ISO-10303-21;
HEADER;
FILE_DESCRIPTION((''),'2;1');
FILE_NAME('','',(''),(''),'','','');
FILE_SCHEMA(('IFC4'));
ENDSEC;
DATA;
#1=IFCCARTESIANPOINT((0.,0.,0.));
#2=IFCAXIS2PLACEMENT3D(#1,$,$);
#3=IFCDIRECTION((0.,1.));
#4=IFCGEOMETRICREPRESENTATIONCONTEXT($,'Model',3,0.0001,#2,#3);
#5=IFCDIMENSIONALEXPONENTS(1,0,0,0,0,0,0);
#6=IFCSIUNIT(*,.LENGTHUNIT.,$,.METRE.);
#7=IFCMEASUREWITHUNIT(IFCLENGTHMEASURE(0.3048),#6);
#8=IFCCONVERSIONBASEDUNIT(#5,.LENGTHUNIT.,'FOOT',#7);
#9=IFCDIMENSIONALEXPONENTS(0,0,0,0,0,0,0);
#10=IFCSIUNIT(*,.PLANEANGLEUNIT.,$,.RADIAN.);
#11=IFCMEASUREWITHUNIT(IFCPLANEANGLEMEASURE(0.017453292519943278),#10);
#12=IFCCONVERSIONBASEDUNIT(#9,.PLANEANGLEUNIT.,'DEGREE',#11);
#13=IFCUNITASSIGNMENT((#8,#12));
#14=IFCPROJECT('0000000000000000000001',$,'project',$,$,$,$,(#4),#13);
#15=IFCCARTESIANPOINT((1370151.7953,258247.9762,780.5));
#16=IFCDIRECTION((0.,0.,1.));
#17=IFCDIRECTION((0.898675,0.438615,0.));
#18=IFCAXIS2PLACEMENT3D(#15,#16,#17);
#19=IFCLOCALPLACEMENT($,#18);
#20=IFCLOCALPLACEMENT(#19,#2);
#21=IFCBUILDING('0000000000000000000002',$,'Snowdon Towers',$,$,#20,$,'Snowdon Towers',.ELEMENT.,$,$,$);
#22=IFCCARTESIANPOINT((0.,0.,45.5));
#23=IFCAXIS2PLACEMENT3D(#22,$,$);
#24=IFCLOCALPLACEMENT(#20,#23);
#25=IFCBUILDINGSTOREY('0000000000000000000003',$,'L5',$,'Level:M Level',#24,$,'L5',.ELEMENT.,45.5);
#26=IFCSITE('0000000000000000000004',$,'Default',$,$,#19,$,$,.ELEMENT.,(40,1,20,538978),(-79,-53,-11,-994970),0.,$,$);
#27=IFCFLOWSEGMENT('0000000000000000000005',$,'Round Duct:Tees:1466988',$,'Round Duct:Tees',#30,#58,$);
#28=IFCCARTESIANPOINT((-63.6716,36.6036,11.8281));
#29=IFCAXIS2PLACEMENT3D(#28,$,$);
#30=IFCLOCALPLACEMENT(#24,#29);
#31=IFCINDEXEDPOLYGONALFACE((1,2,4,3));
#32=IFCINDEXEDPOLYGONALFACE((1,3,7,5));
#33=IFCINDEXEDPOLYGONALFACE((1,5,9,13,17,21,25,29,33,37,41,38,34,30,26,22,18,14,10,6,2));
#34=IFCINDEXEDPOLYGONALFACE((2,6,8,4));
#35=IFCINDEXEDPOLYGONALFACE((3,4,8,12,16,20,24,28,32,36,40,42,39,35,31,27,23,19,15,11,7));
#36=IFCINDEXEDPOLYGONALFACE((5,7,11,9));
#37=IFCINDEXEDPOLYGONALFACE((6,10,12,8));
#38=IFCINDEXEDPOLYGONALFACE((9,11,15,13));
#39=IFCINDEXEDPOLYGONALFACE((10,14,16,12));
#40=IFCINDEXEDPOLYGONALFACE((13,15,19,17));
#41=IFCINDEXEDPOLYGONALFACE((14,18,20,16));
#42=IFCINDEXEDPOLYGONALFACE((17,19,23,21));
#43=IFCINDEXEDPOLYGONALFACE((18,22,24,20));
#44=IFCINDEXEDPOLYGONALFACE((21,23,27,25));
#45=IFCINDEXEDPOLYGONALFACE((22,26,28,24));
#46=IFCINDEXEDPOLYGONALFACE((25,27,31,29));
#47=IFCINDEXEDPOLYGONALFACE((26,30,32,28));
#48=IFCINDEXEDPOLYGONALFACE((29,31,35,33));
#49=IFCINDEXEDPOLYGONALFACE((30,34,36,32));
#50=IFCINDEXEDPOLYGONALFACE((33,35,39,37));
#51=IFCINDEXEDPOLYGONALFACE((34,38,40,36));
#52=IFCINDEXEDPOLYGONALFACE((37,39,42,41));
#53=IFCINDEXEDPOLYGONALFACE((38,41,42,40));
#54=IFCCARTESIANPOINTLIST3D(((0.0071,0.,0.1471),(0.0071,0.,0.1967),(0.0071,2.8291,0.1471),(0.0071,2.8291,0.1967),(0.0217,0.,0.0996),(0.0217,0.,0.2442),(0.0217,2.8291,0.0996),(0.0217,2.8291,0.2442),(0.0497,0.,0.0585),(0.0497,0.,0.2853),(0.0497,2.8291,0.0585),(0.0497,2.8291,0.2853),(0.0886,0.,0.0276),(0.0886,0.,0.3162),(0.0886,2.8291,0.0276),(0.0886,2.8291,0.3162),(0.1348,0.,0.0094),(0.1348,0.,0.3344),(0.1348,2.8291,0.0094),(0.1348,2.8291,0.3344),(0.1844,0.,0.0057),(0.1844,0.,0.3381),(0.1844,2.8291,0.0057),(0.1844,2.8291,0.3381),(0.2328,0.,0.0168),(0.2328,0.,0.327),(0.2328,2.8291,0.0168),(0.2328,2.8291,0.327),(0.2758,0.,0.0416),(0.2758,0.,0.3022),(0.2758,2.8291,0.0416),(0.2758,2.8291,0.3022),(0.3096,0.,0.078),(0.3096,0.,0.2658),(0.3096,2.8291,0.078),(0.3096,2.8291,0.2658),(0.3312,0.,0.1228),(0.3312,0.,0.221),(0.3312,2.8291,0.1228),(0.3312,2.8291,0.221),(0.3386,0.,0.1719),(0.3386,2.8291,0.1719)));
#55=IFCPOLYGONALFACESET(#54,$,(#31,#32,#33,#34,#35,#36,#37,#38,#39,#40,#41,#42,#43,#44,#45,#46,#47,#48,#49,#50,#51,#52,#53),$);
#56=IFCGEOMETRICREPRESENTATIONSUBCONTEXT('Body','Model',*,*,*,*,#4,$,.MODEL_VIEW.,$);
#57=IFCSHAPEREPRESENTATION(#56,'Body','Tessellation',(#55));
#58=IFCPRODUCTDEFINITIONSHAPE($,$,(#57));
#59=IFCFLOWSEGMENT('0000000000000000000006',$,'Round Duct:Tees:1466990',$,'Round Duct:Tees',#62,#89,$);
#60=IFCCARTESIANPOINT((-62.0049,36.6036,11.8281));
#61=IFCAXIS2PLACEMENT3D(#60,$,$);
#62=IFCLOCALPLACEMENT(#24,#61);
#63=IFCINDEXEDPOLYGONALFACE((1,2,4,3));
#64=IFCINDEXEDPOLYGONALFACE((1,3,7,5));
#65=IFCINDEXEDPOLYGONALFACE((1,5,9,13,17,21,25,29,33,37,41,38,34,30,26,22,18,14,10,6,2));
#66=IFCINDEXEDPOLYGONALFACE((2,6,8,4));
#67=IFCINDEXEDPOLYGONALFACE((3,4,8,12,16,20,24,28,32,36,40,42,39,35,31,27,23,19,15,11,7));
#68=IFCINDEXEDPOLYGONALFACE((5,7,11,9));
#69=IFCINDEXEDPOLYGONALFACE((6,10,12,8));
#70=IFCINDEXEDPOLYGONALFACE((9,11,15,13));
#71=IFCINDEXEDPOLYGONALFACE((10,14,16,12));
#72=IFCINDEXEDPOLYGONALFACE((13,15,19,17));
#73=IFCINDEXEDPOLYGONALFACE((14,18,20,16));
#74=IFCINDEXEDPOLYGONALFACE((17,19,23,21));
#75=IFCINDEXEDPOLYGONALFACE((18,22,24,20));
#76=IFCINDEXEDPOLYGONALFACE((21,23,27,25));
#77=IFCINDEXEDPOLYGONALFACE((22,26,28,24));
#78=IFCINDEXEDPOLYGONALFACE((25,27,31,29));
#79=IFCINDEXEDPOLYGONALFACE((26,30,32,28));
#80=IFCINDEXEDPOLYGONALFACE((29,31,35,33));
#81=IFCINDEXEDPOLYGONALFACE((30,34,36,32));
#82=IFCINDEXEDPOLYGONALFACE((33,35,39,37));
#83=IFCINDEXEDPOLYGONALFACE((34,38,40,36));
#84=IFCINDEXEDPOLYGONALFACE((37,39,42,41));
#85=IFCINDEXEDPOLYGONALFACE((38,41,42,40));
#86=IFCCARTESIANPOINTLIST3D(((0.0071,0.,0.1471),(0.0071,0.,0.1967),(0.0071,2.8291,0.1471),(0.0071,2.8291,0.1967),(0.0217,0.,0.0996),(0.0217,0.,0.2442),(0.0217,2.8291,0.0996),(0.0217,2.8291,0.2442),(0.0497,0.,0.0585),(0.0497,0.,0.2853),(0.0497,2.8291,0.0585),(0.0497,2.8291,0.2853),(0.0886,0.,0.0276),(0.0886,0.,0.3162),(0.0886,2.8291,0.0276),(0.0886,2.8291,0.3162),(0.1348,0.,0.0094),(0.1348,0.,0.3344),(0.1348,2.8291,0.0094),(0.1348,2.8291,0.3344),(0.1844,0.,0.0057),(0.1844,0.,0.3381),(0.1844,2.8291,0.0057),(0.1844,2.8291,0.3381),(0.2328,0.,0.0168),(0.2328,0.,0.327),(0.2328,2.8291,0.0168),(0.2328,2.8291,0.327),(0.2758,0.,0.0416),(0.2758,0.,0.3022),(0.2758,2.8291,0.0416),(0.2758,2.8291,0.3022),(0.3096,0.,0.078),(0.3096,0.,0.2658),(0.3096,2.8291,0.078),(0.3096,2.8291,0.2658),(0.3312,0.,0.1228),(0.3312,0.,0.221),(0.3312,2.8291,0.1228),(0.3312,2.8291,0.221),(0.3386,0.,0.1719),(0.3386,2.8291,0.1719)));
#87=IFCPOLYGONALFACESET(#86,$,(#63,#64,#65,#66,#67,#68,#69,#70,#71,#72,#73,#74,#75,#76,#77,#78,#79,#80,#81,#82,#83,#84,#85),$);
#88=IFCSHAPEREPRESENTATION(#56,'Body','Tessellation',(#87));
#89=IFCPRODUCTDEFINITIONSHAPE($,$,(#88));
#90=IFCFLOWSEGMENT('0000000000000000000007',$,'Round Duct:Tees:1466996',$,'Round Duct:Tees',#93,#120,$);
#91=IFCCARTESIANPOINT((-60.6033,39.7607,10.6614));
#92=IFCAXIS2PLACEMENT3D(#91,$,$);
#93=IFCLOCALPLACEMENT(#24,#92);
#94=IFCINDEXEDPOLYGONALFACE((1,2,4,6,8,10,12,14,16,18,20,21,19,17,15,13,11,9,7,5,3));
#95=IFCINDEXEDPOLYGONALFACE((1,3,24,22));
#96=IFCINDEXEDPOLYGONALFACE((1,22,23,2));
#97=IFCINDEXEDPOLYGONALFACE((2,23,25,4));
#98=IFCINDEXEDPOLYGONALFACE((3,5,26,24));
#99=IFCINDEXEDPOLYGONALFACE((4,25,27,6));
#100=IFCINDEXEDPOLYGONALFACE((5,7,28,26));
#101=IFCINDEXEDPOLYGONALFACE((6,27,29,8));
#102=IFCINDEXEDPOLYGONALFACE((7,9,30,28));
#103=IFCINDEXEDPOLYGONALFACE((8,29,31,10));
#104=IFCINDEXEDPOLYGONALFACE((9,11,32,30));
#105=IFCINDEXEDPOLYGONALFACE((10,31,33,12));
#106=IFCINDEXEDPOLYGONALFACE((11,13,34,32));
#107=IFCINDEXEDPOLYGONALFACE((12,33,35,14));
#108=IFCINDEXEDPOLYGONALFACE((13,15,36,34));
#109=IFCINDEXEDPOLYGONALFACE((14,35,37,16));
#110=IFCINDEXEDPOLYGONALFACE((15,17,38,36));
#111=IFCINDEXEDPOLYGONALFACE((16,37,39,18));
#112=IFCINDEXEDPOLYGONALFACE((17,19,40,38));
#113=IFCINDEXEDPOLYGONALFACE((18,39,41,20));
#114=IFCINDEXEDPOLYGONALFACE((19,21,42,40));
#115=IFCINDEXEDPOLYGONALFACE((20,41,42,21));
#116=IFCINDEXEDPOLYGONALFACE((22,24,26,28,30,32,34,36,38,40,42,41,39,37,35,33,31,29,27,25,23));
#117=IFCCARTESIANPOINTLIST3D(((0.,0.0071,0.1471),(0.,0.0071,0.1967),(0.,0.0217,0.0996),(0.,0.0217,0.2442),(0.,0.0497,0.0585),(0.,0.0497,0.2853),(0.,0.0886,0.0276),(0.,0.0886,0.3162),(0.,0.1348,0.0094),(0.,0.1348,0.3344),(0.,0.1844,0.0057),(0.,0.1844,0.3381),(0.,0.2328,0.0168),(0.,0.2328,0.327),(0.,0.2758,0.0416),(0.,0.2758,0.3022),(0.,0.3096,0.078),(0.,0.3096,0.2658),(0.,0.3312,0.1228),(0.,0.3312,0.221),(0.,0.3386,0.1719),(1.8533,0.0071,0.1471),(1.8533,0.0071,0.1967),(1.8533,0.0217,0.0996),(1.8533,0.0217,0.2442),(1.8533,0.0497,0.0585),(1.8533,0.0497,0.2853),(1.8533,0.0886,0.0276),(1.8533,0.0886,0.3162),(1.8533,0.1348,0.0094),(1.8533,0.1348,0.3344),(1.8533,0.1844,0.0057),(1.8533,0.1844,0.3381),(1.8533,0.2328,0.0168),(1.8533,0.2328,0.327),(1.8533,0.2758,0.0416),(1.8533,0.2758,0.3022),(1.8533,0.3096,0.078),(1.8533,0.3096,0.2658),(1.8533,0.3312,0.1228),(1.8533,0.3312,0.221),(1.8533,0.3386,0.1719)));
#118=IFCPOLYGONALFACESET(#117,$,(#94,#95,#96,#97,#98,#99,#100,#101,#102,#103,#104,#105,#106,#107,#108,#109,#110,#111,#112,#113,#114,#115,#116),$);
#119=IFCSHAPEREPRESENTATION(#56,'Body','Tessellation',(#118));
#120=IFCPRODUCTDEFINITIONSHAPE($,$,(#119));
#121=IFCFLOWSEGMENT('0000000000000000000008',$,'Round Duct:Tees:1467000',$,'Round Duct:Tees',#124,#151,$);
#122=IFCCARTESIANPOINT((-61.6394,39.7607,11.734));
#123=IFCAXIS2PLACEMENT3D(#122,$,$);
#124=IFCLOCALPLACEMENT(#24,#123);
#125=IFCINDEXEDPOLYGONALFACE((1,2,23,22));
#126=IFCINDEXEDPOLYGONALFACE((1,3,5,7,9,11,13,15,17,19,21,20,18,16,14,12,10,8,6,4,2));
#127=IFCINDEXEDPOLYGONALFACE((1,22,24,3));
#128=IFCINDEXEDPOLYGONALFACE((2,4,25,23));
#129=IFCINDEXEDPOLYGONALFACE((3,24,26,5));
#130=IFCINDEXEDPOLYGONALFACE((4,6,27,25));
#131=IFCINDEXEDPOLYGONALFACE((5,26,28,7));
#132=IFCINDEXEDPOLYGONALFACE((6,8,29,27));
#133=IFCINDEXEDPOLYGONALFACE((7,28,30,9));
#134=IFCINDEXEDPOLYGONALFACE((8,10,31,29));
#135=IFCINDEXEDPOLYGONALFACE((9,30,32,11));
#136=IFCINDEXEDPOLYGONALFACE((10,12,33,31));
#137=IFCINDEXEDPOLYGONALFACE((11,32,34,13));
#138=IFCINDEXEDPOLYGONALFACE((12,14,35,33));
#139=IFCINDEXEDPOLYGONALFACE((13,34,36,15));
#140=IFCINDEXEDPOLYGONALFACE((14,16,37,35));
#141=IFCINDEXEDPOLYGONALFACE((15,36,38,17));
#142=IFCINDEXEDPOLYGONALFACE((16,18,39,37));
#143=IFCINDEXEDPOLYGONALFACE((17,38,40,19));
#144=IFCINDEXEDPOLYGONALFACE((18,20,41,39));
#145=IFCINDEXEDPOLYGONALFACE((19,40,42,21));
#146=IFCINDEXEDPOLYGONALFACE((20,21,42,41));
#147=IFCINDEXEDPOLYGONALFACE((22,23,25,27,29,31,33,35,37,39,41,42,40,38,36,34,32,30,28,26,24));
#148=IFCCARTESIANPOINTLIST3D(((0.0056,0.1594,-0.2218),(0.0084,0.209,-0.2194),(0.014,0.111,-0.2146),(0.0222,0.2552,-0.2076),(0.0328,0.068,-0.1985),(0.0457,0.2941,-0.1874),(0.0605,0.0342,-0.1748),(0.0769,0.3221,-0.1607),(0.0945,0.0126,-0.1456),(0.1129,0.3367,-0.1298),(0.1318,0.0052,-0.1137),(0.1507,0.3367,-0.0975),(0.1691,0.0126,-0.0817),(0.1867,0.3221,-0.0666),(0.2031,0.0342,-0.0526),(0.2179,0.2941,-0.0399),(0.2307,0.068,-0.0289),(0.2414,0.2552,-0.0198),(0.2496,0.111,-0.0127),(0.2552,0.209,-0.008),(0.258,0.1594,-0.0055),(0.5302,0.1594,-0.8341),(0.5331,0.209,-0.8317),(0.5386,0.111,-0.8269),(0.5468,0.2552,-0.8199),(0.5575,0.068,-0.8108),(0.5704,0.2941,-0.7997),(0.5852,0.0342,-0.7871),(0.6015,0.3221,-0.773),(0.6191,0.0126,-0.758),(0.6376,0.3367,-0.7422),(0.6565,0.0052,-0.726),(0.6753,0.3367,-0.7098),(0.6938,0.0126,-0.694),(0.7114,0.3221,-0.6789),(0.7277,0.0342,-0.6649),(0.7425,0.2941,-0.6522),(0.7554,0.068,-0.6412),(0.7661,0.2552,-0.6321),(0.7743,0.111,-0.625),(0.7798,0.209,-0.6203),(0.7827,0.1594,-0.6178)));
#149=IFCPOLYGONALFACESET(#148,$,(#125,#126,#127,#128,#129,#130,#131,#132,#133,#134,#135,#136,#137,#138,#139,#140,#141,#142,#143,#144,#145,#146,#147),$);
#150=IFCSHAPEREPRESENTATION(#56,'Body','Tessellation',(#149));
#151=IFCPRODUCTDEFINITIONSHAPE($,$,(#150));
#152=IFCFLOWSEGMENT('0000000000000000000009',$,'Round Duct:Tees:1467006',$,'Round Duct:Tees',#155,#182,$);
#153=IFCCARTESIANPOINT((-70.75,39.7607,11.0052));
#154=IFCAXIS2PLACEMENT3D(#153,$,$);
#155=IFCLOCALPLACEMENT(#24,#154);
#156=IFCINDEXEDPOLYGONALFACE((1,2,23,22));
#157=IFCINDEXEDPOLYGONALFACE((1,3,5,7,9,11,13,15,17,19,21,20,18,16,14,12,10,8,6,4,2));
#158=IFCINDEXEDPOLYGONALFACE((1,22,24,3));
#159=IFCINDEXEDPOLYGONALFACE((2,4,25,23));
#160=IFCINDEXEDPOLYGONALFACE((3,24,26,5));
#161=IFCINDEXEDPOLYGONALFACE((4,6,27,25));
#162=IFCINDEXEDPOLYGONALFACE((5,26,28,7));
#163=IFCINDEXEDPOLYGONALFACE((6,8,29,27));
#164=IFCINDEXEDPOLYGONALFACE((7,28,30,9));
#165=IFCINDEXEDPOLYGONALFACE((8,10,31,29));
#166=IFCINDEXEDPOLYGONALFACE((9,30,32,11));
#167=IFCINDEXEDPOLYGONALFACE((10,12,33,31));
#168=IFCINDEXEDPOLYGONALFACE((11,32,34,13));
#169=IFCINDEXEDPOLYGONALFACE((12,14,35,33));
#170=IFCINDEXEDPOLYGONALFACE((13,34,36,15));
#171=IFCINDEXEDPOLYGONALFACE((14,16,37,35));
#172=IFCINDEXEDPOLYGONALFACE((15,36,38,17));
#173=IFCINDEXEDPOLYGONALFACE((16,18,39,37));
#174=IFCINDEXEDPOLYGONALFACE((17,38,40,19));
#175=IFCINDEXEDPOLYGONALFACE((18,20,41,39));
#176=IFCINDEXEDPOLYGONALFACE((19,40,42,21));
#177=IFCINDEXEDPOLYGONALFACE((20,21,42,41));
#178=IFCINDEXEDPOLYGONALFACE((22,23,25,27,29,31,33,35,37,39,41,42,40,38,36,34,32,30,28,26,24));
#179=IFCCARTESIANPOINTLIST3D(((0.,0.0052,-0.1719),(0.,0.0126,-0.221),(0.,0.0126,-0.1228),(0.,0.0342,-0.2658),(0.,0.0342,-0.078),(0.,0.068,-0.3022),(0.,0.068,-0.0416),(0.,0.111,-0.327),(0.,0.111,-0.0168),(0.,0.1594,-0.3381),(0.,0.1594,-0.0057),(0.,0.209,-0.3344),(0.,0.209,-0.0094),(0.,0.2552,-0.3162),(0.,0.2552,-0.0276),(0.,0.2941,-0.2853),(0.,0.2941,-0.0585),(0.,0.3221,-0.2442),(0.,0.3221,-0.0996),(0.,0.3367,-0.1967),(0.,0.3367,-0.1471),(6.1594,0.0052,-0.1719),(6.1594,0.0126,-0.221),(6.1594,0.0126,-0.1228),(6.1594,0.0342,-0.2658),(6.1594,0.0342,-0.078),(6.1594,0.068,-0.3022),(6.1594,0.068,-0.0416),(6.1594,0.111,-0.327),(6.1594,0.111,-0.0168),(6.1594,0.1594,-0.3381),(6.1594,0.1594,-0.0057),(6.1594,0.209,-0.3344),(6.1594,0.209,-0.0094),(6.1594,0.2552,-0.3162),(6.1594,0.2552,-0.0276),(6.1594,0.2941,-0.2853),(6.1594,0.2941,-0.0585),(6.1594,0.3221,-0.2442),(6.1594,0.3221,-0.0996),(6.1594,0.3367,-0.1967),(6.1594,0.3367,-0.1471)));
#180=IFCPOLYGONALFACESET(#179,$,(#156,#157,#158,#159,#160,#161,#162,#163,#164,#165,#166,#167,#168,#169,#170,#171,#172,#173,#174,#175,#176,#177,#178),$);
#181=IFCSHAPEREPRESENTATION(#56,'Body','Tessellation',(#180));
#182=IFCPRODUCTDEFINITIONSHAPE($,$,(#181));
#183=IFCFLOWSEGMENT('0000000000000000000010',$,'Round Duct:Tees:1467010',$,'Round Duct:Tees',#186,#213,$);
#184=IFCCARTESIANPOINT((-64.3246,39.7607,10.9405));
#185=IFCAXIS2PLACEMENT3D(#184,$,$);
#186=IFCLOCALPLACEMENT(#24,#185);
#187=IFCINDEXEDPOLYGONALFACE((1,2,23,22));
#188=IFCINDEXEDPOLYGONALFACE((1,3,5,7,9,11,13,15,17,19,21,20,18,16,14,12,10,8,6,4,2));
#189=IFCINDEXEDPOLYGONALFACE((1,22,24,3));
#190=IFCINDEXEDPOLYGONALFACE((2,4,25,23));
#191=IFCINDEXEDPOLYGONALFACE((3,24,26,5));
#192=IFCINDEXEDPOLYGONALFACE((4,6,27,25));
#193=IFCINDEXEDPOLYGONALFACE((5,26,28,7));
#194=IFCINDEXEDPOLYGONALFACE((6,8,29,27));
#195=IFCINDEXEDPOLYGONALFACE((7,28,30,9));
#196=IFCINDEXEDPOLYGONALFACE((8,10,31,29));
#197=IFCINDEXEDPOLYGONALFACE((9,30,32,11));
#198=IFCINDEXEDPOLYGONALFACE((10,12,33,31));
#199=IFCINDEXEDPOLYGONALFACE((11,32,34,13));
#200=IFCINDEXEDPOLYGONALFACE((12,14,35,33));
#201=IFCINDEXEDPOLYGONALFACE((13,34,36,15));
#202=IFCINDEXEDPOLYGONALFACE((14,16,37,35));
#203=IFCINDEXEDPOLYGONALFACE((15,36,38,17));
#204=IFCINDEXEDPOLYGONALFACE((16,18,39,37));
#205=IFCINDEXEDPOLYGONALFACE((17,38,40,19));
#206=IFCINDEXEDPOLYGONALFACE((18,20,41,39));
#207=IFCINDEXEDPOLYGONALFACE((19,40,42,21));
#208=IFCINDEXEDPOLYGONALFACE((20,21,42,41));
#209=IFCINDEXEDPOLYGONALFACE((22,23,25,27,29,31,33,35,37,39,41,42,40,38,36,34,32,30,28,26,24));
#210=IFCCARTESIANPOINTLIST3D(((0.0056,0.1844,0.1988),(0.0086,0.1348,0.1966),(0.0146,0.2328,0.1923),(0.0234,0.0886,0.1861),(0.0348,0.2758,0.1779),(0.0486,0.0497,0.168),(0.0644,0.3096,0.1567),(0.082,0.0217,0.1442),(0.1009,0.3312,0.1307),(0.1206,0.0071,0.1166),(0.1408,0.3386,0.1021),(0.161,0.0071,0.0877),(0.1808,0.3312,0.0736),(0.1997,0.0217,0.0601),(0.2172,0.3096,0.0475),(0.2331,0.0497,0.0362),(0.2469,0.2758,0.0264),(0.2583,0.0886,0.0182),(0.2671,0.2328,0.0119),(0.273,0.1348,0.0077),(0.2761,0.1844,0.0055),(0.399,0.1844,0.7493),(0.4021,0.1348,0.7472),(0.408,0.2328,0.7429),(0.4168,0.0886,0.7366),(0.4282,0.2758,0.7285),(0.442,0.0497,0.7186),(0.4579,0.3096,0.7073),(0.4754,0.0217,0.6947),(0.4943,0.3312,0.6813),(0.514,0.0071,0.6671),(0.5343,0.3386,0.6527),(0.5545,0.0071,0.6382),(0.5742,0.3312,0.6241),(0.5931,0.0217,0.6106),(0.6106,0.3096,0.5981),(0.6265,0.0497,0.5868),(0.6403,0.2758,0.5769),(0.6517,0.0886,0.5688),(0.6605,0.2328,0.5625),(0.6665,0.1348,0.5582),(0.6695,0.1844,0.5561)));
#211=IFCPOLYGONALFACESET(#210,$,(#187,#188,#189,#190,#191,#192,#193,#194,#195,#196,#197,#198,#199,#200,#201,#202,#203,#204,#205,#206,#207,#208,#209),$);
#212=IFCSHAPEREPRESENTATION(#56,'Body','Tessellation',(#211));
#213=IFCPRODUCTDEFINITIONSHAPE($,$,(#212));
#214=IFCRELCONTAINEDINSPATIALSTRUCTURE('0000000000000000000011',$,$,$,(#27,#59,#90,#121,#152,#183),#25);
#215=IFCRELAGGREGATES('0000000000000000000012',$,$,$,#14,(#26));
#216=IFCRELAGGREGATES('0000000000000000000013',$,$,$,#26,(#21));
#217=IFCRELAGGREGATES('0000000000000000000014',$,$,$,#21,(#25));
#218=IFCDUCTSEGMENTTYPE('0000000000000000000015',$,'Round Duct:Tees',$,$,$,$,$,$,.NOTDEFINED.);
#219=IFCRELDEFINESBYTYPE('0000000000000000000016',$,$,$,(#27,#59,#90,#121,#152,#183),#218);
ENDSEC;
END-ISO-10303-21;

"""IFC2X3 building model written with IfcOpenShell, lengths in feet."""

from ifc_helpers import new_model, entity, si_unit, converted_unit, direction, frame, frame_2d, origin, place, context, subcontext, project, spatial, circle, extrude, type_object, element, save


model = new_model("IFC2X3")

# Units and contexts
model_context = context("Model", 3, precision=0.0001, world=origin(), true_north=direction((0.0, 1.0)))
body_context = subcontext(model_context, "Body", "Model", "MODEL_VIEW")
ifc_project = project(units=[converted_unit("LENGTHUNIT", "FOOT", entity("IfcLengthMeasure", 0.3048), si_unit("LENGTHUNIT", "METRE"), dimensions=[1, 0, 0, 0, 0, 0, 0]), converted_unit("PLANEANGLEUNIT", "DEGREE", entity("IfcPlaneAngleMeasure", 0.017453292519943278), si_unit("PLANEANGLEUNIT", "RADIAN"), dimensions=[0, 0, 0, 0, 0, 0, 0])], contexts=[model_context])

# Site, building, storey
site_placement = place(None, frame((1370151.7953, 258247.9762, 780.5), z_axis=(0.0, 0.0, 1.0), x_axis=(0.898675, 0.438615, 0.0)))
site = spatial("IfcSite", under=ifc_project, at=site_placement, Name="Default", CompositionType="ELEMENT", RefLatitude=(40, 1, 20, 538978), RefLongitude=(-79, -53, -11, -994970), RefElevation=0.0)
building_placement = place(site_placement, origin())
building = spatial("IfcBuilding", under=site, at=building_placement, Name="Snowdon Towers", LongName="Snowdon Towers", CompositionType="ELEMENT")
storey_placement = place(building_placement, frame((0.0, 0.0, 45.5)))
storey = spatial("IfcBuildingStorey", under=building, at=storey_placement, Name="L5", ObjectType="Level:M Level", LongName="L5", CompositionType="ELEMENT", Elevation=45.5)

# Flow segments
duct_segment_type = type_object("IfcDuctSegmentType", Name="Round Duct:Tees", PredefinedType="NOTDEFINED")
flow_segment_1_placement = place(storey_placement, frame((-63.6716, 36.6036, 11.8281)))
element("IfcFlowSegment", 1, at=flow_segment_1_placement, inside=storey, type_object=duct_segment_type, Name="Round Duct:Tees:1466988", ObjectType="Round Duct:Tees", context=body_context, shape_type="SweptSolid", body=[
    extrude(circle(Radius=0.1667, at=frame_2d((0.0, 0.0), x_axis=(1.0, 0.0))), frame((0.1719, 0.0, 0.1719), z_axis=(0.0, 1.0, 0.0), x_axis=(1.0, 0.0, 0.0)), (0.0, 0.0, 1.0), 2.8291),
])
flow_segment_2_placement = place(storey_placement, frame((-62.0049, 36.6036, 11.8281)))
element("IfcFlowSegment", 2, at=flow_segment_2_placement, inside=storey, type_object=duct_segment_type, Name="Round Duct:Tees:1466990", ObjectType="Round Duct:Tees", context=body_context, shape_type="SweptSolid", body=[
    extrude(circle(Radius=0.1667, at=frame_2d((0.0, 0.0), x_axis=(1.0, 0.0))), frame((0.1719, 0.0, 0.1719), z_axis=(0.0, 1.0, 0.0), x_axis=(1.0, 0.0, 0.0)), (0.0, 0.0, 1.0), 2.8291),
])
flow_segment_3_placement = place(storey_placement, frame((-60.6033, 39.7607, 10.6614)))
element("IfcFlowSegment", 3, at=flow_segment_3_placement, inside=storey, type_object=duct_segment_type, Name="Round Duct:Tees:1466996", ObjectType="Round Duct:Tees", context=body_context, shape_type="SweptSolid", body=[
    extrude(circle(Radius=0.1667, at=frame_2d((0.0, 0.0), x_axis=(1.0, 0.0))), frame((0.0, 0.1719, 0.1719), z_axis=(1.0, 0.0, 0.0), x_axis=(0.0, 1.0, 0.0)), (0.0, 0.0, 1.0), 1.8533),
])
flow_segment_4_placement = place(storey_placement, frame((-61.6394, 39.7607, 11.734)))
element("IfcFlowSegment", 4, at=flow_segment_4_placement, inside=storey, type_object=duct_segment_type, Name="Round Duct:Tees:1467000", ObjectType="Round Duct:Tees", context=body_context, shape_type="SweptSolid", body=[
    extrude(circle(Radius=0.1667, at=frame_2d((0.0, 0.0), x_axis=(1.0, 0.0))), frame((0.1318, 0.1719, -0.1137), z_axis=(0.65066, 0.0, -0.759369), x_axis=(0.0, -1.0, 0.0)), (0.0, 0.0, 1.0), 0.8063),
])
flow_segment_5_placement = place(storey_placement, frame((-70.75, 39.7607, 11.0052)))
element("IfcFlowSegment", 5, at=flow_segment_5_placement, inside=storey, type_object=duct_segment_type, Name="Round Duct:Tees:1467006", ObjectType="Round Duct:Tees", context=body_context, shape_type="SweptSolid", body=[
    extrude(circle(Radius=0.1667, at=frame_2d((0.0, 0.0), x_axis=(1.0, 0.0))), frame((0.0, 0.1719, -0.1719), z_axis=(1.0, 0.0, 0.0), x_axis=(0.0, -1.0, 0.0)), (0.0, 0.0, 1.0), 6.1594),
])
flow_segment_6_placement = place(storey_placement, frame((-64.3246, 39.7607, 10.9405)))
element("IfcFlowSegment", 6, at=flow_segment_6_placement, inside=storey, type_object=duct_segment_type, Name="Round Duct:Tees:1467010", ObjectType="Round Duct:Tees", context=body_context, shape_type="SweptSolid", body=[
    extrude(circle(Radius=0.1667, at=frame_2d((0.0, 0.0), x_axis=(1.0, 0.0))), frame((0.1408, 0.1719, 0.1021), z_axis=(0.5814, 0.0, 0.813618), x_axis=(0.0, 1.0, 0.0)), (0.0, 0.0, 1.0), 0.6767),
])

save(model, "model.ifc")
